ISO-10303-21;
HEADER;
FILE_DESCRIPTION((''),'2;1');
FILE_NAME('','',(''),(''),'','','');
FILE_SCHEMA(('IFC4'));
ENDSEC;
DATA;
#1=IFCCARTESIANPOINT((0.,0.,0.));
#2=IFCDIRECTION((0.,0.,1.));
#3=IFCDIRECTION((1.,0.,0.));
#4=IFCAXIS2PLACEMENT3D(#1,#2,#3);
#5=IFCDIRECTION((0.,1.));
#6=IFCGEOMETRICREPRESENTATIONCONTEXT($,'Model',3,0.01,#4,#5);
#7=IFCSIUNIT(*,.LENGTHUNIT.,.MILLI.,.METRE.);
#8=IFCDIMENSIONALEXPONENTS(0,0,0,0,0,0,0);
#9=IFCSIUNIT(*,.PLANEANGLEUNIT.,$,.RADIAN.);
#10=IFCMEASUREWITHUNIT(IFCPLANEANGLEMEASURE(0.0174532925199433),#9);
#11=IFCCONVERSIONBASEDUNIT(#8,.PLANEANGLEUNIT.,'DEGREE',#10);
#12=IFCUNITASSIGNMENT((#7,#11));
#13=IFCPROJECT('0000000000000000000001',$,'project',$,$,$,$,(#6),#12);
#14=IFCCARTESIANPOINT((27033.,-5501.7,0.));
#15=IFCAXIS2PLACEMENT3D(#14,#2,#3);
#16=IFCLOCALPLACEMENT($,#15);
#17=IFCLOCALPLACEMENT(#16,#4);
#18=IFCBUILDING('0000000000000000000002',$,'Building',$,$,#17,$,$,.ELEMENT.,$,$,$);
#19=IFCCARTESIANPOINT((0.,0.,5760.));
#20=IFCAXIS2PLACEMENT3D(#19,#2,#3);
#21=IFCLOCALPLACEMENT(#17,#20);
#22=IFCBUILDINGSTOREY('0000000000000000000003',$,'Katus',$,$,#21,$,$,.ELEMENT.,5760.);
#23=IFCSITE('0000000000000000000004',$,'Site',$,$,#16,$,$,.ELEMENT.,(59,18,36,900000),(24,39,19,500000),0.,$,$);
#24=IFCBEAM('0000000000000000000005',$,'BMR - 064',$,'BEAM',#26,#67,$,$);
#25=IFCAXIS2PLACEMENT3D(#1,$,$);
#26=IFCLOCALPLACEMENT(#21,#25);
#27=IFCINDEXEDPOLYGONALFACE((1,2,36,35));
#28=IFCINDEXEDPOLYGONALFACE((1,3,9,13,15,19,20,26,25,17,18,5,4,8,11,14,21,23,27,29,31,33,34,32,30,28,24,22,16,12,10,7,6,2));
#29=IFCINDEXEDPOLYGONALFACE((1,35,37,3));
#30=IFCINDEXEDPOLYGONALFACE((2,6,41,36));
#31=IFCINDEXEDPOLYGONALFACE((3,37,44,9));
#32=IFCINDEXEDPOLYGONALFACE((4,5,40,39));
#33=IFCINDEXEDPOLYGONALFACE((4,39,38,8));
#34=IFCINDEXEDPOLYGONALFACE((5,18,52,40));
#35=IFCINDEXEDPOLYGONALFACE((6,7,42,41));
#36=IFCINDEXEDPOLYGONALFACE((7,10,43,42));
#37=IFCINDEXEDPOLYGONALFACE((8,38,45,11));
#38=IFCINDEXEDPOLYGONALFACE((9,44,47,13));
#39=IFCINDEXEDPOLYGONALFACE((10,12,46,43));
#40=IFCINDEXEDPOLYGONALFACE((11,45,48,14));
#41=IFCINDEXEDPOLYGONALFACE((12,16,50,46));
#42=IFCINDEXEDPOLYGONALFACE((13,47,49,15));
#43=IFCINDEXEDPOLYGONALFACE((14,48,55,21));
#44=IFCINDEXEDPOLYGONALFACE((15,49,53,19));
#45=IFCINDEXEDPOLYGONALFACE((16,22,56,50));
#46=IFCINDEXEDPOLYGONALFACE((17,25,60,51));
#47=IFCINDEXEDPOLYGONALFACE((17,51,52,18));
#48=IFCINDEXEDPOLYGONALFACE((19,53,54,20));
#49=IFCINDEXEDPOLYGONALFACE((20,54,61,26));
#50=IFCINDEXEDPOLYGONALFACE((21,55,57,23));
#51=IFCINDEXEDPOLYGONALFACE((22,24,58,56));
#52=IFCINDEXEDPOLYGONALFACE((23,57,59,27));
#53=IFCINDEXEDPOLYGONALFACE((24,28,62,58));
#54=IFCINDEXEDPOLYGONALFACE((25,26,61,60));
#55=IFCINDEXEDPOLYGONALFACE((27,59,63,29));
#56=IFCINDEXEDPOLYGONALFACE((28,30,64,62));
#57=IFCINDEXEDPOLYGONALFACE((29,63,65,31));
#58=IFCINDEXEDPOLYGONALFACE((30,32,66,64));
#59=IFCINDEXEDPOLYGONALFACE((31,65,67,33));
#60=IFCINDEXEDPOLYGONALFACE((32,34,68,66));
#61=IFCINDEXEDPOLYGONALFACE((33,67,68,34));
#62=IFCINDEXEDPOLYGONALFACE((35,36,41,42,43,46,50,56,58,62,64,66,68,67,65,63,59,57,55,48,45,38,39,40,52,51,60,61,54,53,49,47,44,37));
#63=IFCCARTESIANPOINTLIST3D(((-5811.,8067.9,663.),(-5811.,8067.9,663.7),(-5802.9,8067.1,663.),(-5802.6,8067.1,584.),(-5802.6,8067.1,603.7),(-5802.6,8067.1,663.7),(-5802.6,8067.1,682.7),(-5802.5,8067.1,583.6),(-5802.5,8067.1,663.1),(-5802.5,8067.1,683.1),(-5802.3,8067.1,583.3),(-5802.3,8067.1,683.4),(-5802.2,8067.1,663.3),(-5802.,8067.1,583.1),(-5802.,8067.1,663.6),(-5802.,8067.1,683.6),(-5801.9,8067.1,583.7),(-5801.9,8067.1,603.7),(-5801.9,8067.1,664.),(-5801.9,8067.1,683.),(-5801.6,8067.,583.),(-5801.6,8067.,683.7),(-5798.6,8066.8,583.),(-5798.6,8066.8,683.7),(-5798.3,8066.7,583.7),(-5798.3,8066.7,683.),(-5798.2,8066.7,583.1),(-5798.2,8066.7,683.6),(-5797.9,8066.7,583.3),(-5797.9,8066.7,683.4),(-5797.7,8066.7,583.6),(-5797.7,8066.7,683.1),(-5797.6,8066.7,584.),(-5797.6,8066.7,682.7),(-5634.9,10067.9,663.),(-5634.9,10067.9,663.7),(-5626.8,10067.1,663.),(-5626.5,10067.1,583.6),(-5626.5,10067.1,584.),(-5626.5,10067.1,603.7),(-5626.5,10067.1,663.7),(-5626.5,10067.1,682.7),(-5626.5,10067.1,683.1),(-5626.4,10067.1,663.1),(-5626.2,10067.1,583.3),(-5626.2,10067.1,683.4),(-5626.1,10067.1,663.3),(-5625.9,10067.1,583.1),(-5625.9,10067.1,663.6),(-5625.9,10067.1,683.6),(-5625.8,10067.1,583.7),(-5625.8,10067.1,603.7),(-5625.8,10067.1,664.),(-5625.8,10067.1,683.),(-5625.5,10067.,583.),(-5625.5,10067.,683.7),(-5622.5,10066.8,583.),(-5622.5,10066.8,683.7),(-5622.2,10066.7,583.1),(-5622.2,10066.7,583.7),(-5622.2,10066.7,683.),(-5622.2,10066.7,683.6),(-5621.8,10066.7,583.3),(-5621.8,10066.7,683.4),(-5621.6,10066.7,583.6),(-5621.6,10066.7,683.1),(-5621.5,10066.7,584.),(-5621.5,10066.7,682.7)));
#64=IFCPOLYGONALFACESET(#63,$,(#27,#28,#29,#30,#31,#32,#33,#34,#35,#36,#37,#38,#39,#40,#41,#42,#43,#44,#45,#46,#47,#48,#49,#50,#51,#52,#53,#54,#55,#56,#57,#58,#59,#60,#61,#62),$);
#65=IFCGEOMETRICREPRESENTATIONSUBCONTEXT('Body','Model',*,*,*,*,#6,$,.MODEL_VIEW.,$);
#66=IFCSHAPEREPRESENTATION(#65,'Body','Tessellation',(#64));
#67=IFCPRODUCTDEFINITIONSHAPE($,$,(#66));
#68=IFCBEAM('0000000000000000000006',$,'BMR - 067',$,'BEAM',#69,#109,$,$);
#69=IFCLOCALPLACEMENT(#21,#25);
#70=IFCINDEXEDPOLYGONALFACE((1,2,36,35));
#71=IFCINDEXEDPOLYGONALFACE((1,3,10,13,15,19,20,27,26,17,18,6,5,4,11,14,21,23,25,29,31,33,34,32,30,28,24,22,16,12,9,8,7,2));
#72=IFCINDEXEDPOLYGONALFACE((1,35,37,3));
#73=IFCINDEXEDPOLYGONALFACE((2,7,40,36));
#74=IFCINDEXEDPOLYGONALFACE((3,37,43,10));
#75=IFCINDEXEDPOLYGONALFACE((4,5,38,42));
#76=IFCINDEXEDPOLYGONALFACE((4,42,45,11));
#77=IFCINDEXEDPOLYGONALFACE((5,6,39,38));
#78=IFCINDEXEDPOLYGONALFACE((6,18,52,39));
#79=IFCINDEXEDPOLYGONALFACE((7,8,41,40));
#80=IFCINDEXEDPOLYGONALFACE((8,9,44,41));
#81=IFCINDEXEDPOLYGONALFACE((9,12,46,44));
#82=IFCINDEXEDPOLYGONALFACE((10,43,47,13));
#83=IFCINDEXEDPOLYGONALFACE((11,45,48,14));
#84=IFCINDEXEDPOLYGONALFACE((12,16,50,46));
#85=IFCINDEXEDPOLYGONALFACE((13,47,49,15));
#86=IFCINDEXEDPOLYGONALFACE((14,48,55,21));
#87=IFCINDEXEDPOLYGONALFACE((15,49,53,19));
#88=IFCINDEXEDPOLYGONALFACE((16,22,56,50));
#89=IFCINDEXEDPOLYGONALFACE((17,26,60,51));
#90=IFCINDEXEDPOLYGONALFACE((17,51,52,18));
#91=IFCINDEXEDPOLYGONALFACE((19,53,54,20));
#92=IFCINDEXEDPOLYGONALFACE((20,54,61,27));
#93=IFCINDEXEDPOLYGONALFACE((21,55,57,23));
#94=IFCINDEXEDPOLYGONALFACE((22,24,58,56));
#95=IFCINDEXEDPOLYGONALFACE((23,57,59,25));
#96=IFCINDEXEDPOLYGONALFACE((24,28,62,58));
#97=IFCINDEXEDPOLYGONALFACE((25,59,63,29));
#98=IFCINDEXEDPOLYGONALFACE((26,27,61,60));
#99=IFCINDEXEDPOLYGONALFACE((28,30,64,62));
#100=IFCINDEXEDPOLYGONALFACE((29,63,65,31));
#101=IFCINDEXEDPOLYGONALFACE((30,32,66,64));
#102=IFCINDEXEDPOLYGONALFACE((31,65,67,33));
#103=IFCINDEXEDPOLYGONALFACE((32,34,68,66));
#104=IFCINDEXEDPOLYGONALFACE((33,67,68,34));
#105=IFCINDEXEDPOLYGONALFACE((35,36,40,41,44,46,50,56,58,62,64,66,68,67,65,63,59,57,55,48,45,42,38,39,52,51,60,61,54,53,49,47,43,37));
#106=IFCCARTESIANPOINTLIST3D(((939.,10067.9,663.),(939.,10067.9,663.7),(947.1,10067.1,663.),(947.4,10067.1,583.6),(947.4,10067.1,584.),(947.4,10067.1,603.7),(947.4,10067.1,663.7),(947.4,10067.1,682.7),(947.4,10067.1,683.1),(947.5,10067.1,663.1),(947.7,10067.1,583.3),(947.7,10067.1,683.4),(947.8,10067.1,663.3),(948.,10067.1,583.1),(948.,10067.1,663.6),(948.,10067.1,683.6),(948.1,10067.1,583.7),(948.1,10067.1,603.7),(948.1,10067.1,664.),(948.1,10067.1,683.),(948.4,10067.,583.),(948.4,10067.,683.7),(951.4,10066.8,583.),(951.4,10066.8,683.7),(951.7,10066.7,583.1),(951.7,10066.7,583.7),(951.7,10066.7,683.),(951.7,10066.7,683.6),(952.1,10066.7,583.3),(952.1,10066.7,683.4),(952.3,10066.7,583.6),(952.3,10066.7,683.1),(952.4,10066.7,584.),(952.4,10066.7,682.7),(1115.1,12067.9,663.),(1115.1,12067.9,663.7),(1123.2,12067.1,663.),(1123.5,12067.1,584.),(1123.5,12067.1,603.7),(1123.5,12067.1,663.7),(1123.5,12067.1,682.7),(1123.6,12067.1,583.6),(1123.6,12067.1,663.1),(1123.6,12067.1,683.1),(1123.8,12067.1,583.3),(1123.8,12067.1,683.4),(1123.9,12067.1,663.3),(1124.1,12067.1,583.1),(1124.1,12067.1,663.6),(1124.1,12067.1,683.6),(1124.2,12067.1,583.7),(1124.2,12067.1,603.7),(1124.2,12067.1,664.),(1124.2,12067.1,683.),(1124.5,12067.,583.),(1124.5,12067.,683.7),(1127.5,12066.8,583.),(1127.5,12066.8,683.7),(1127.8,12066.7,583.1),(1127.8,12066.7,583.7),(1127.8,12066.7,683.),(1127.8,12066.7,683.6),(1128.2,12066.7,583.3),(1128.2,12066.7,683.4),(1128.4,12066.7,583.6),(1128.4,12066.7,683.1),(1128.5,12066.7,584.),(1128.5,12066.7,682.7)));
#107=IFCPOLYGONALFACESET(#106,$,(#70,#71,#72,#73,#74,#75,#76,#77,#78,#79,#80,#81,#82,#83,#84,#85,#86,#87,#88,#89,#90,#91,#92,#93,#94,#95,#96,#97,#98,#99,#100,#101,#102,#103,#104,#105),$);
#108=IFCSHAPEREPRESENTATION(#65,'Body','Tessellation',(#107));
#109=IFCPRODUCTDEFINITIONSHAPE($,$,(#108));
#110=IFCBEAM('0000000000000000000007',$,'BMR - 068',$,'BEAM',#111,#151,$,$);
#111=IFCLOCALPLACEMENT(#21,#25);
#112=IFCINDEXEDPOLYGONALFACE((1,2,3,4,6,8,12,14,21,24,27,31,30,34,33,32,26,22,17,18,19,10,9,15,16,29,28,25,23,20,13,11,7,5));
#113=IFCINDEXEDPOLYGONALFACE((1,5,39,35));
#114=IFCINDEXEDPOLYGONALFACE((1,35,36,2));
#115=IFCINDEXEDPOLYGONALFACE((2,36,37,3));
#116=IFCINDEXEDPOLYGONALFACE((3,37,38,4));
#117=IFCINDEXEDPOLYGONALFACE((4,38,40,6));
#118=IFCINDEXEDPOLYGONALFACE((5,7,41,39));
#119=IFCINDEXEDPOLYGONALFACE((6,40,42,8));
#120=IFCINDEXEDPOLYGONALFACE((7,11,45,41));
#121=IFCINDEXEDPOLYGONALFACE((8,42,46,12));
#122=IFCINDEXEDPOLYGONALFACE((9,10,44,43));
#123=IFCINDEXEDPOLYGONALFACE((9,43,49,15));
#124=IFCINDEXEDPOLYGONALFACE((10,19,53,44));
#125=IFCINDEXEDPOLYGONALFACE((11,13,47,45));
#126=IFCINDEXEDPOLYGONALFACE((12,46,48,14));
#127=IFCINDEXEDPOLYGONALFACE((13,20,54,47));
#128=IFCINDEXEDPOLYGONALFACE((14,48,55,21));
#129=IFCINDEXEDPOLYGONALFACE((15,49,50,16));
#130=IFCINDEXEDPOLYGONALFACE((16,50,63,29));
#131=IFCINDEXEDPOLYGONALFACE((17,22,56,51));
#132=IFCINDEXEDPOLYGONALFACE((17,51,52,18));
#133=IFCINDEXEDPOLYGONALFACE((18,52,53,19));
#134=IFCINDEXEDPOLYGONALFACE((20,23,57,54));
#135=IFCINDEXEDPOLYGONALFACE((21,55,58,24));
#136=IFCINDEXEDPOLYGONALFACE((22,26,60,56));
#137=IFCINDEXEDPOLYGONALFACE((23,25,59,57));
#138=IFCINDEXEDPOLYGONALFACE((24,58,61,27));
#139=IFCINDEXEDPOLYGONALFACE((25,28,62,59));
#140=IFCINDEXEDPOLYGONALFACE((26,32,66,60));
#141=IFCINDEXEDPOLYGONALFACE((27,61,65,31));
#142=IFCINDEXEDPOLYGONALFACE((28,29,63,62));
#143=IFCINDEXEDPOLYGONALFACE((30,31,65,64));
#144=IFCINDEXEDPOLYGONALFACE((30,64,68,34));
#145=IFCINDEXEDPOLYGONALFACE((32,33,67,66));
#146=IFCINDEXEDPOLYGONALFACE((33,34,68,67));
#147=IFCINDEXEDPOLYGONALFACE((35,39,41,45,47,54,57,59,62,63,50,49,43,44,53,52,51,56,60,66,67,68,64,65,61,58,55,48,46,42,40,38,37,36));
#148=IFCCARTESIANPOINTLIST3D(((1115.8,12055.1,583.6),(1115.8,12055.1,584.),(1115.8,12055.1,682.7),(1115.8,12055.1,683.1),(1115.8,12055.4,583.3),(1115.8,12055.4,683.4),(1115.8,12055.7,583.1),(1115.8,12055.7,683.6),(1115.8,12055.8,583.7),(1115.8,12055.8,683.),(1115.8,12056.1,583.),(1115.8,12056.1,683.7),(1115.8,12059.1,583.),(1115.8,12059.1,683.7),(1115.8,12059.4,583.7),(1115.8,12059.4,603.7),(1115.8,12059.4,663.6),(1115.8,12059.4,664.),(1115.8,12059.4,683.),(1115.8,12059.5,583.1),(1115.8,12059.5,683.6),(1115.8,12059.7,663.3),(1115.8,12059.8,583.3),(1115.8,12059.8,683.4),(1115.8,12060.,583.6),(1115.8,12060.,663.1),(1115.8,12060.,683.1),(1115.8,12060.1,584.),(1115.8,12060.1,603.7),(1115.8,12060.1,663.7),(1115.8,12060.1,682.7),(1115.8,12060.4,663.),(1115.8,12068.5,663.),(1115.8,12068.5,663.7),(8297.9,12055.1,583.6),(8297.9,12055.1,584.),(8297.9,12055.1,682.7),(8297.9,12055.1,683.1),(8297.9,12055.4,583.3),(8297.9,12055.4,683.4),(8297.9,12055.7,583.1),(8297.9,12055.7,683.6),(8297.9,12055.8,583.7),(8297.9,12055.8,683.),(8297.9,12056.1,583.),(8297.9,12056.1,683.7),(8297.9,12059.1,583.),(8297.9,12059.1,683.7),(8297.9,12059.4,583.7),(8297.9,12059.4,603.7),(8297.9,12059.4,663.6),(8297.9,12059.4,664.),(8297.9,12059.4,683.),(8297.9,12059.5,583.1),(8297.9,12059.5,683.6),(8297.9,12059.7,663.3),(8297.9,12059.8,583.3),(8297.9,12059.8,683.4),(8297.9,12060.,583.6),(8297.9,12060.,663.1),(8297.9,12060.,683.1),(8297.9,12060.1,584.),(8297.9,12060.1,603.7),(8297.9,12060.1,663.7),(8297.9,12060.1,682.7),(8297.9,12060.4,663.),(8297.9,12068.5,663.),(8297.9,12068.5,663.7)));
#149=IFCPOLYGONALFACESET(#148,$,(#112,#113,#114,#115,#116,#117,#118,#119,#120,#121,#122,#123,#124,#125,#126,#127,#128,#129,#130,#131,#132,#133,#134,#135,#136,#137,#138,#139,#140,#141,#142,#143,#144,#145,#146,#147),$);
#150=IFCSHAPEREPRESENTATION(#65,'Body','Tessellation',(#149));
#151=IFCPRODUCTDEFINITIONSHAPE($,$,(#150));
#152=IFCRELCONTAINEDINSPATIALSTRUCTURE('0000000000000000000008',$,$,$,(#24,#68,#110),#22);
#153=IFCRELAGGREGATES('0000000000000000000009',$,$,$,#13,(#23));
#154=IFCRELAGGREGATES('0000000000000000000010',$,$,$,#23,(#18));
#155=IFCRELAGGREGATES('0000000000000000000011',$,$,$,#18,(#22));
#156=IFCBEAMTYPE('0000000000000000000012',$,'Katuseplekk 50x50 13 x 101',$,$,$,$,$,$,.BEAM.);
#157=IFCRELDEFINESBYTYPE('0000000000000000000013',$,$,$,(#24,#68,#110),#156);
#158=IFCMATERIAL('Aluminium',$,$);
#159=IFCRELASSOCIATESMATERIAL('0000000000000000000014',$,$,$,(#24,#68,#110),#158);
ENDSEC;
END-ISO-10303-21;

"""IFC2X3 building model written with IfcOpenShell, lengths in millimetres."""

from ifc_helpers import new_model, entity, si_unit, converted_unit, point, direction, frame, frame_2d, origin_with_axes, place, context, subcontext, project, spatial, polyline, circle_curve, parameter, trimmed, segment, composite_curve, outline, extrude, material, type_object, element, save


model = new_model("IFC2X3")

# Units and contexts
model_context = context("Model", 3, precision=0.01, world=origin_with_axes(), true_north=direction((0.0, 1.0)))
body_context = subcontext(model_context, "Body", "Model", "MODEL_VIEW")
ifc_project = project(units=[si_unit("LENGTHUNIT", "METRE", prefix="MILLI"), converted_unit("PLANEANGLEUNIT", "DEGREE", entity("IfcPlaneAngleMeasure", 0.0174532925199433), si_unit("PLANEANGLEUNIT", "RADIAN"), dimensions=[0, 0, 0, 0, 0, 0, 0])], contexts=[model_context])

# Site, building, storey
site_placement = place(None, frame((27033.0, -5501.7, 0.0), z_axis=(0.0, 0.0, 1.0), x_axis=(1.0, 0.0, 0.0)))
site = spatial("IfcSite", under=ifc_project, at=site_placement, Name="Site", CompositionType="ELEMENT", RefLatitude=(59, 18, 36, 900000), RefLongitude=(24, 39, 19, 500000), RefElevation=0.0)
building_placement = place(site_placement, origin_with_axes())
building = spatial("IfcBuilding", under=site, at=building_placement, Name="Building", CompositionType="ELEMENT")
storey_placement = place(building_placement, frame((0.0, 0.0, 5760.0), z_axis=(0.0, 0.0, 1.0), x_axis=(1.0, 0.0, 0.0)))
storey = spatial("IfcBuildingStorey", under=building, at=storey_placement, Name="Katus", CompositionType="ELEMENT", Elevation=5760.0)

# Beams
ifc_material_1 = material(Name="Aluminium")
beam_type = type_object("IfcBeamType", Name="Katuseplekk 50x50 13 x 101", PredefinedType="BEAM")
beam_1_placement = place(storey_placement, frame((-5810.3, 8067.8, 663.0), z_axis=(0.0, 0.0, 1.0), x_axis=(0.996148, -0.087686, 0.0)))
element("IfcBeam", 1, at=beam_1_placement, inside=storey, type_object=beam_type, material=ifc_material_1, Name="BMR - 064", ObjectType="BEAM", context=body_context, shape_type="SweptSolid", body=[
    extrude(outline(composite_curve([segment(polyline([(-0.7, 0.0), (7.4, 0.0)]), True, "CONTINUOUS"), segment(trimmed(circle_curve(frame_2d((7.4, 1.0), x_axis=(0.0, -1.0)), 1.0), [point((7.4, 0.0)), parameter(0.0)], [point((8.4, 1.0)), parameter(90.0)], True, "CARTESIAN"), True, "CONTINUOUS"), segment(polyline([(8.4, 1.0), (8.4, 20.0), (12.0, 20.0), (12.0, -79.3), (8.4, -79.3), (8.4, -59.3), (7.7, -59.3), (7.7, -79.0)]), True, "CONTINUOUS"), segment(trimmed(circle_curve(frame_2d((8.7, -79.0), x_axis=(-1.0, 0.0)), 1.0), [point((7.7, -79.0)), parameter(0.0)], [point((8.7, -80.0)), parameter(90.0)], True, "CARTESIAN"), True, "CONTINUOUS"), segment(polyline([(8.7, -80.0), (11.7, -80.0)]), True, "CONTINUOUS"), segment(trimmed(circle_curve(frame_2d((11.7, -79.0), x_axis=(0.0, -1.0)), 1.0), [point((11.7, -80.0)), parameter(0.0)], [point((12.7, -79.0)), parameter(90.0)], True, "CARTESIAN"), True, "CONTINUOUS"), segment(polyline([(12.7, -79.0), (12.7, 19.7)]), True, "CONTINUOUS"), segment(trimmed(circle_curve(frame_2d((11.7, 19.7), x_axis=(1.0, 0.0)), 1.0), [point((12.7, 19.7)), parameter(0.0)], [point((11.7, 20.7)), parameter(90.0)], True, "CARTESIAN"), True, "CONTINUOUS"), segment(polyline([(11.7, 20.7), (8.7, 20.7)]), True, "CONTINUOUS"), segment(trimmed(circle_curve(frame_2d((8.7, 19.7), x_axis=(0.0, 1.0)), 1.0), [point((8.7, 20.7)), parameter(0.0)], [point((7.7, 19.7)), parameter(90.0)], True, "CARTESIAN"), True, "CONTINUOUS"), segment(polyline([(7.7, 19.7), (7.7, 0.7), (-0.7, 0.7), (-0.7, 0.0)]), True, "CONTINUOUS")], self_intersect=False)), frame((0.0, 2007.7, 0.0), z_axis=(0.0, -1.0, 0.0), x_axis=(1.0, 0.0, 0.0)), (0.0, 0.0, 1.0), 2007.7),
])
beam_2_placement = place(storey_placement, frame((939.7, 10067.8, 663.0), z_axis=(0.0, 0.0, 1.0), x_axis=(0.996146, -0.087713, 0.0)))
element("IfcBeam", 2, at=beam_2_placement, inside=storey, type_object=beam_type, material=ifc_material_1, Name="BMR - 067", ObjectType="BEAM", context=body_context, shape_type="SweptSolid", body=[
    extrude(outline(composite_curve([segment(polyline([(-0.7, 0.0), (7.4, 0.0)]), True, "CONTINUOUS"), segment(trimmed(circle_curve(frame_2d((7.4, 1.0), x_axis=(0.0, -1.0)), 1.0), [point((7.4, 0.0)), parameter(0.0)], [point((8.4, 1.0)), parameter(90.0)], True, "CARTESIAN"), True, "CONTINUOUS"), segment(polyline([(8.4, 1.0), (8.4, 20.0), (12.0, 20.0), (12.0, -79.3), (8.4, -79.3), (8.4, -59.3), (7.7, -59.3), (7.7, -79.0)]), True, "CONTINUOUS"), segment(trimmed(circle_curve(frame_2d((8.7, -79.0), x_axis=(-1.0, 0.0)), 1.0), [point((7.7, -79.0)), parameter(0.0)], [point((8.7, -80.0)), parameter(90.0)], True, "CARTESIAN"), True, "CONTINUOUS"), segment(polyline([(8.7, -80.0), (11.7, -80.0)]), True, "CONTINUOUS"), segment(trimmed(circle_curve(frame_2d((11.7, -79.0), x_axis=(0.0, -1.0)), 1.0), [point((11.7, -80.0)), parameter(0.0)], [point((12.7, -79.0)), parameter(90.0)], True, "CARTESIAN"), True, "CONTINUOUS"), segment(polyline([(12.7, -79.0), (12.7, 19.7)]), True, "CONTINUOUS"), segment(trimmed(circle_curve(frame_2d((11.7, 19.7), x_axis=(1.0, 0.0)), 1.0), [point((12.7, 19.7)), parameter(0.0)], [point((11.7, 20.7)), parameter(90.0)], True, "CARTESIAN"), True, "CONTINUOUS"), segment(polyline([(11.7, 20.7), (8.7, 20.7)]), True, "CONTINUOUS"), segment(trimmed(circle_curve(frame_2d((8.7, 19.7), x_axis=(0.0, 1.0)), 1.0), [point((8.7, 20.7)), parameter(0.0)], [point((7.7, 19.7)), parameter(90.0)], True, "CARTESIAN"), True, "CONTINUOUS"), segment(polyline([(7.7, 19.7), (7.7, 0.7), (-0.7, 0.7), (-0.7, 0.0)]), True, "CONTINUOUS")], self_intersect=False)), frame((0.0, 2007.7, 0.0), z_axis=(0.0, -1.0, 0.0), x_axis=(1.0, 0.0, 0.0)), (0.0, 0.0, 1.0), 2007.7),
])
beam_3_placement = place(storey_placement, frame((1115.8, 12067.8, 663.0), z_axis=(0.0, 0.0, 1.0), x_axis=(0.0, -1.0, 0.0)))
element("IfcBeam", 3, at=beam_3_placement, inside=storey, type_object=beam_type, material=ifc_material_1, Name="BMR - 068", ObjectType="BEAM", context=body_context, shape_type="SweptSolid", body=[
    extrude(outline(composite_curve([segment(polyline([(-0.7, 0.0), (7.4, 0.0)]), True, "CONTINUOUS"), segment(trimmed(circle_curve(frame_2d((7.4, 1.0), x_axis=(0.0, -1.0)), 1.0), [point((7.4, 0.0)), parameter(0.0)], [point((8.4, 1.0)), parameter(90.0)], True, "CARTESIAN"), True, "CONTINUOUS"), segment(polyline([(8.4, 1.0), (8.4, 20.0), (12.0, 20.0), (12.0, -79.3), (8.4, -79.3), (8.4, -59.3), (7.7, -59.3), (7.7, -79.0)]), True, "CONTINUOUS"), segment(trimmed(circle_curve(frame_2d((8.7, -79.0), x_axis=(-1.0, 0.0)), 1.0), [point((7.7, -79.0)), parameter(0.0)], [point((8.7, -80.0)), parameter(90.0)], True, "CARTESIAN"), True, "CONTINUOUS"), segment(polyline([(8.7, -80.0), (11.7, -80.0)]), True, "CONTINUOUS"), segment(trimmed(circle_curve(frame_2d((11.7, -79.0), x_axis=(0.0, -1.0)), 1.0), [point((11.7, -80.0)), parameter(0.0)], [point((12.7, -79.0)), parameter(90.0)], True, "CARTESIAN"), True, "CONTINUOUS"), segment(polyline([(12.7, -79.0), (12.7, 19.7)]), True, "CONTINUOUS"), segment(trimmed(circle_curve(frame_2d((11.7, 19.7), x_axis=(1.0, 0.0)), 1.0), [point((12.7, 19.7)), parameter(0.0)], [point((11.7, 20.7)), parameter(90.0)], True, "CARTESIAN"), True, "CONTINUOUS"), segment(polyline([(11.7, 20.7), (8.7, 20.7)]), True, "CONTINUOUS"), segment(trimmed(circle_curve(frame_2d((8.7, 19.7), x_axis=(0.0, 1.0)), 1.0), [point((8.7, 20.7)), parameter(0.0)], [point((7.7, 19.7)), parameter(90.0)], True, "CARTESIAN"), True, "CONTINUOUS"), segment(polyline([(7.7, 19.7), (7.7, 0.7), (-0.7, 0.7), (-0.7, 0.0)]), True, "CONTINUOUS")], self_intersect=False)), frame((0.0, 7182.2, 0.0), z_axis=(0.0, -1.0, 0.0), x_axis=(1.0, 0.0, 0.0)), (0.0, 0.0, 1.0), 7182.2),
])

save(model, "model.ifc")
